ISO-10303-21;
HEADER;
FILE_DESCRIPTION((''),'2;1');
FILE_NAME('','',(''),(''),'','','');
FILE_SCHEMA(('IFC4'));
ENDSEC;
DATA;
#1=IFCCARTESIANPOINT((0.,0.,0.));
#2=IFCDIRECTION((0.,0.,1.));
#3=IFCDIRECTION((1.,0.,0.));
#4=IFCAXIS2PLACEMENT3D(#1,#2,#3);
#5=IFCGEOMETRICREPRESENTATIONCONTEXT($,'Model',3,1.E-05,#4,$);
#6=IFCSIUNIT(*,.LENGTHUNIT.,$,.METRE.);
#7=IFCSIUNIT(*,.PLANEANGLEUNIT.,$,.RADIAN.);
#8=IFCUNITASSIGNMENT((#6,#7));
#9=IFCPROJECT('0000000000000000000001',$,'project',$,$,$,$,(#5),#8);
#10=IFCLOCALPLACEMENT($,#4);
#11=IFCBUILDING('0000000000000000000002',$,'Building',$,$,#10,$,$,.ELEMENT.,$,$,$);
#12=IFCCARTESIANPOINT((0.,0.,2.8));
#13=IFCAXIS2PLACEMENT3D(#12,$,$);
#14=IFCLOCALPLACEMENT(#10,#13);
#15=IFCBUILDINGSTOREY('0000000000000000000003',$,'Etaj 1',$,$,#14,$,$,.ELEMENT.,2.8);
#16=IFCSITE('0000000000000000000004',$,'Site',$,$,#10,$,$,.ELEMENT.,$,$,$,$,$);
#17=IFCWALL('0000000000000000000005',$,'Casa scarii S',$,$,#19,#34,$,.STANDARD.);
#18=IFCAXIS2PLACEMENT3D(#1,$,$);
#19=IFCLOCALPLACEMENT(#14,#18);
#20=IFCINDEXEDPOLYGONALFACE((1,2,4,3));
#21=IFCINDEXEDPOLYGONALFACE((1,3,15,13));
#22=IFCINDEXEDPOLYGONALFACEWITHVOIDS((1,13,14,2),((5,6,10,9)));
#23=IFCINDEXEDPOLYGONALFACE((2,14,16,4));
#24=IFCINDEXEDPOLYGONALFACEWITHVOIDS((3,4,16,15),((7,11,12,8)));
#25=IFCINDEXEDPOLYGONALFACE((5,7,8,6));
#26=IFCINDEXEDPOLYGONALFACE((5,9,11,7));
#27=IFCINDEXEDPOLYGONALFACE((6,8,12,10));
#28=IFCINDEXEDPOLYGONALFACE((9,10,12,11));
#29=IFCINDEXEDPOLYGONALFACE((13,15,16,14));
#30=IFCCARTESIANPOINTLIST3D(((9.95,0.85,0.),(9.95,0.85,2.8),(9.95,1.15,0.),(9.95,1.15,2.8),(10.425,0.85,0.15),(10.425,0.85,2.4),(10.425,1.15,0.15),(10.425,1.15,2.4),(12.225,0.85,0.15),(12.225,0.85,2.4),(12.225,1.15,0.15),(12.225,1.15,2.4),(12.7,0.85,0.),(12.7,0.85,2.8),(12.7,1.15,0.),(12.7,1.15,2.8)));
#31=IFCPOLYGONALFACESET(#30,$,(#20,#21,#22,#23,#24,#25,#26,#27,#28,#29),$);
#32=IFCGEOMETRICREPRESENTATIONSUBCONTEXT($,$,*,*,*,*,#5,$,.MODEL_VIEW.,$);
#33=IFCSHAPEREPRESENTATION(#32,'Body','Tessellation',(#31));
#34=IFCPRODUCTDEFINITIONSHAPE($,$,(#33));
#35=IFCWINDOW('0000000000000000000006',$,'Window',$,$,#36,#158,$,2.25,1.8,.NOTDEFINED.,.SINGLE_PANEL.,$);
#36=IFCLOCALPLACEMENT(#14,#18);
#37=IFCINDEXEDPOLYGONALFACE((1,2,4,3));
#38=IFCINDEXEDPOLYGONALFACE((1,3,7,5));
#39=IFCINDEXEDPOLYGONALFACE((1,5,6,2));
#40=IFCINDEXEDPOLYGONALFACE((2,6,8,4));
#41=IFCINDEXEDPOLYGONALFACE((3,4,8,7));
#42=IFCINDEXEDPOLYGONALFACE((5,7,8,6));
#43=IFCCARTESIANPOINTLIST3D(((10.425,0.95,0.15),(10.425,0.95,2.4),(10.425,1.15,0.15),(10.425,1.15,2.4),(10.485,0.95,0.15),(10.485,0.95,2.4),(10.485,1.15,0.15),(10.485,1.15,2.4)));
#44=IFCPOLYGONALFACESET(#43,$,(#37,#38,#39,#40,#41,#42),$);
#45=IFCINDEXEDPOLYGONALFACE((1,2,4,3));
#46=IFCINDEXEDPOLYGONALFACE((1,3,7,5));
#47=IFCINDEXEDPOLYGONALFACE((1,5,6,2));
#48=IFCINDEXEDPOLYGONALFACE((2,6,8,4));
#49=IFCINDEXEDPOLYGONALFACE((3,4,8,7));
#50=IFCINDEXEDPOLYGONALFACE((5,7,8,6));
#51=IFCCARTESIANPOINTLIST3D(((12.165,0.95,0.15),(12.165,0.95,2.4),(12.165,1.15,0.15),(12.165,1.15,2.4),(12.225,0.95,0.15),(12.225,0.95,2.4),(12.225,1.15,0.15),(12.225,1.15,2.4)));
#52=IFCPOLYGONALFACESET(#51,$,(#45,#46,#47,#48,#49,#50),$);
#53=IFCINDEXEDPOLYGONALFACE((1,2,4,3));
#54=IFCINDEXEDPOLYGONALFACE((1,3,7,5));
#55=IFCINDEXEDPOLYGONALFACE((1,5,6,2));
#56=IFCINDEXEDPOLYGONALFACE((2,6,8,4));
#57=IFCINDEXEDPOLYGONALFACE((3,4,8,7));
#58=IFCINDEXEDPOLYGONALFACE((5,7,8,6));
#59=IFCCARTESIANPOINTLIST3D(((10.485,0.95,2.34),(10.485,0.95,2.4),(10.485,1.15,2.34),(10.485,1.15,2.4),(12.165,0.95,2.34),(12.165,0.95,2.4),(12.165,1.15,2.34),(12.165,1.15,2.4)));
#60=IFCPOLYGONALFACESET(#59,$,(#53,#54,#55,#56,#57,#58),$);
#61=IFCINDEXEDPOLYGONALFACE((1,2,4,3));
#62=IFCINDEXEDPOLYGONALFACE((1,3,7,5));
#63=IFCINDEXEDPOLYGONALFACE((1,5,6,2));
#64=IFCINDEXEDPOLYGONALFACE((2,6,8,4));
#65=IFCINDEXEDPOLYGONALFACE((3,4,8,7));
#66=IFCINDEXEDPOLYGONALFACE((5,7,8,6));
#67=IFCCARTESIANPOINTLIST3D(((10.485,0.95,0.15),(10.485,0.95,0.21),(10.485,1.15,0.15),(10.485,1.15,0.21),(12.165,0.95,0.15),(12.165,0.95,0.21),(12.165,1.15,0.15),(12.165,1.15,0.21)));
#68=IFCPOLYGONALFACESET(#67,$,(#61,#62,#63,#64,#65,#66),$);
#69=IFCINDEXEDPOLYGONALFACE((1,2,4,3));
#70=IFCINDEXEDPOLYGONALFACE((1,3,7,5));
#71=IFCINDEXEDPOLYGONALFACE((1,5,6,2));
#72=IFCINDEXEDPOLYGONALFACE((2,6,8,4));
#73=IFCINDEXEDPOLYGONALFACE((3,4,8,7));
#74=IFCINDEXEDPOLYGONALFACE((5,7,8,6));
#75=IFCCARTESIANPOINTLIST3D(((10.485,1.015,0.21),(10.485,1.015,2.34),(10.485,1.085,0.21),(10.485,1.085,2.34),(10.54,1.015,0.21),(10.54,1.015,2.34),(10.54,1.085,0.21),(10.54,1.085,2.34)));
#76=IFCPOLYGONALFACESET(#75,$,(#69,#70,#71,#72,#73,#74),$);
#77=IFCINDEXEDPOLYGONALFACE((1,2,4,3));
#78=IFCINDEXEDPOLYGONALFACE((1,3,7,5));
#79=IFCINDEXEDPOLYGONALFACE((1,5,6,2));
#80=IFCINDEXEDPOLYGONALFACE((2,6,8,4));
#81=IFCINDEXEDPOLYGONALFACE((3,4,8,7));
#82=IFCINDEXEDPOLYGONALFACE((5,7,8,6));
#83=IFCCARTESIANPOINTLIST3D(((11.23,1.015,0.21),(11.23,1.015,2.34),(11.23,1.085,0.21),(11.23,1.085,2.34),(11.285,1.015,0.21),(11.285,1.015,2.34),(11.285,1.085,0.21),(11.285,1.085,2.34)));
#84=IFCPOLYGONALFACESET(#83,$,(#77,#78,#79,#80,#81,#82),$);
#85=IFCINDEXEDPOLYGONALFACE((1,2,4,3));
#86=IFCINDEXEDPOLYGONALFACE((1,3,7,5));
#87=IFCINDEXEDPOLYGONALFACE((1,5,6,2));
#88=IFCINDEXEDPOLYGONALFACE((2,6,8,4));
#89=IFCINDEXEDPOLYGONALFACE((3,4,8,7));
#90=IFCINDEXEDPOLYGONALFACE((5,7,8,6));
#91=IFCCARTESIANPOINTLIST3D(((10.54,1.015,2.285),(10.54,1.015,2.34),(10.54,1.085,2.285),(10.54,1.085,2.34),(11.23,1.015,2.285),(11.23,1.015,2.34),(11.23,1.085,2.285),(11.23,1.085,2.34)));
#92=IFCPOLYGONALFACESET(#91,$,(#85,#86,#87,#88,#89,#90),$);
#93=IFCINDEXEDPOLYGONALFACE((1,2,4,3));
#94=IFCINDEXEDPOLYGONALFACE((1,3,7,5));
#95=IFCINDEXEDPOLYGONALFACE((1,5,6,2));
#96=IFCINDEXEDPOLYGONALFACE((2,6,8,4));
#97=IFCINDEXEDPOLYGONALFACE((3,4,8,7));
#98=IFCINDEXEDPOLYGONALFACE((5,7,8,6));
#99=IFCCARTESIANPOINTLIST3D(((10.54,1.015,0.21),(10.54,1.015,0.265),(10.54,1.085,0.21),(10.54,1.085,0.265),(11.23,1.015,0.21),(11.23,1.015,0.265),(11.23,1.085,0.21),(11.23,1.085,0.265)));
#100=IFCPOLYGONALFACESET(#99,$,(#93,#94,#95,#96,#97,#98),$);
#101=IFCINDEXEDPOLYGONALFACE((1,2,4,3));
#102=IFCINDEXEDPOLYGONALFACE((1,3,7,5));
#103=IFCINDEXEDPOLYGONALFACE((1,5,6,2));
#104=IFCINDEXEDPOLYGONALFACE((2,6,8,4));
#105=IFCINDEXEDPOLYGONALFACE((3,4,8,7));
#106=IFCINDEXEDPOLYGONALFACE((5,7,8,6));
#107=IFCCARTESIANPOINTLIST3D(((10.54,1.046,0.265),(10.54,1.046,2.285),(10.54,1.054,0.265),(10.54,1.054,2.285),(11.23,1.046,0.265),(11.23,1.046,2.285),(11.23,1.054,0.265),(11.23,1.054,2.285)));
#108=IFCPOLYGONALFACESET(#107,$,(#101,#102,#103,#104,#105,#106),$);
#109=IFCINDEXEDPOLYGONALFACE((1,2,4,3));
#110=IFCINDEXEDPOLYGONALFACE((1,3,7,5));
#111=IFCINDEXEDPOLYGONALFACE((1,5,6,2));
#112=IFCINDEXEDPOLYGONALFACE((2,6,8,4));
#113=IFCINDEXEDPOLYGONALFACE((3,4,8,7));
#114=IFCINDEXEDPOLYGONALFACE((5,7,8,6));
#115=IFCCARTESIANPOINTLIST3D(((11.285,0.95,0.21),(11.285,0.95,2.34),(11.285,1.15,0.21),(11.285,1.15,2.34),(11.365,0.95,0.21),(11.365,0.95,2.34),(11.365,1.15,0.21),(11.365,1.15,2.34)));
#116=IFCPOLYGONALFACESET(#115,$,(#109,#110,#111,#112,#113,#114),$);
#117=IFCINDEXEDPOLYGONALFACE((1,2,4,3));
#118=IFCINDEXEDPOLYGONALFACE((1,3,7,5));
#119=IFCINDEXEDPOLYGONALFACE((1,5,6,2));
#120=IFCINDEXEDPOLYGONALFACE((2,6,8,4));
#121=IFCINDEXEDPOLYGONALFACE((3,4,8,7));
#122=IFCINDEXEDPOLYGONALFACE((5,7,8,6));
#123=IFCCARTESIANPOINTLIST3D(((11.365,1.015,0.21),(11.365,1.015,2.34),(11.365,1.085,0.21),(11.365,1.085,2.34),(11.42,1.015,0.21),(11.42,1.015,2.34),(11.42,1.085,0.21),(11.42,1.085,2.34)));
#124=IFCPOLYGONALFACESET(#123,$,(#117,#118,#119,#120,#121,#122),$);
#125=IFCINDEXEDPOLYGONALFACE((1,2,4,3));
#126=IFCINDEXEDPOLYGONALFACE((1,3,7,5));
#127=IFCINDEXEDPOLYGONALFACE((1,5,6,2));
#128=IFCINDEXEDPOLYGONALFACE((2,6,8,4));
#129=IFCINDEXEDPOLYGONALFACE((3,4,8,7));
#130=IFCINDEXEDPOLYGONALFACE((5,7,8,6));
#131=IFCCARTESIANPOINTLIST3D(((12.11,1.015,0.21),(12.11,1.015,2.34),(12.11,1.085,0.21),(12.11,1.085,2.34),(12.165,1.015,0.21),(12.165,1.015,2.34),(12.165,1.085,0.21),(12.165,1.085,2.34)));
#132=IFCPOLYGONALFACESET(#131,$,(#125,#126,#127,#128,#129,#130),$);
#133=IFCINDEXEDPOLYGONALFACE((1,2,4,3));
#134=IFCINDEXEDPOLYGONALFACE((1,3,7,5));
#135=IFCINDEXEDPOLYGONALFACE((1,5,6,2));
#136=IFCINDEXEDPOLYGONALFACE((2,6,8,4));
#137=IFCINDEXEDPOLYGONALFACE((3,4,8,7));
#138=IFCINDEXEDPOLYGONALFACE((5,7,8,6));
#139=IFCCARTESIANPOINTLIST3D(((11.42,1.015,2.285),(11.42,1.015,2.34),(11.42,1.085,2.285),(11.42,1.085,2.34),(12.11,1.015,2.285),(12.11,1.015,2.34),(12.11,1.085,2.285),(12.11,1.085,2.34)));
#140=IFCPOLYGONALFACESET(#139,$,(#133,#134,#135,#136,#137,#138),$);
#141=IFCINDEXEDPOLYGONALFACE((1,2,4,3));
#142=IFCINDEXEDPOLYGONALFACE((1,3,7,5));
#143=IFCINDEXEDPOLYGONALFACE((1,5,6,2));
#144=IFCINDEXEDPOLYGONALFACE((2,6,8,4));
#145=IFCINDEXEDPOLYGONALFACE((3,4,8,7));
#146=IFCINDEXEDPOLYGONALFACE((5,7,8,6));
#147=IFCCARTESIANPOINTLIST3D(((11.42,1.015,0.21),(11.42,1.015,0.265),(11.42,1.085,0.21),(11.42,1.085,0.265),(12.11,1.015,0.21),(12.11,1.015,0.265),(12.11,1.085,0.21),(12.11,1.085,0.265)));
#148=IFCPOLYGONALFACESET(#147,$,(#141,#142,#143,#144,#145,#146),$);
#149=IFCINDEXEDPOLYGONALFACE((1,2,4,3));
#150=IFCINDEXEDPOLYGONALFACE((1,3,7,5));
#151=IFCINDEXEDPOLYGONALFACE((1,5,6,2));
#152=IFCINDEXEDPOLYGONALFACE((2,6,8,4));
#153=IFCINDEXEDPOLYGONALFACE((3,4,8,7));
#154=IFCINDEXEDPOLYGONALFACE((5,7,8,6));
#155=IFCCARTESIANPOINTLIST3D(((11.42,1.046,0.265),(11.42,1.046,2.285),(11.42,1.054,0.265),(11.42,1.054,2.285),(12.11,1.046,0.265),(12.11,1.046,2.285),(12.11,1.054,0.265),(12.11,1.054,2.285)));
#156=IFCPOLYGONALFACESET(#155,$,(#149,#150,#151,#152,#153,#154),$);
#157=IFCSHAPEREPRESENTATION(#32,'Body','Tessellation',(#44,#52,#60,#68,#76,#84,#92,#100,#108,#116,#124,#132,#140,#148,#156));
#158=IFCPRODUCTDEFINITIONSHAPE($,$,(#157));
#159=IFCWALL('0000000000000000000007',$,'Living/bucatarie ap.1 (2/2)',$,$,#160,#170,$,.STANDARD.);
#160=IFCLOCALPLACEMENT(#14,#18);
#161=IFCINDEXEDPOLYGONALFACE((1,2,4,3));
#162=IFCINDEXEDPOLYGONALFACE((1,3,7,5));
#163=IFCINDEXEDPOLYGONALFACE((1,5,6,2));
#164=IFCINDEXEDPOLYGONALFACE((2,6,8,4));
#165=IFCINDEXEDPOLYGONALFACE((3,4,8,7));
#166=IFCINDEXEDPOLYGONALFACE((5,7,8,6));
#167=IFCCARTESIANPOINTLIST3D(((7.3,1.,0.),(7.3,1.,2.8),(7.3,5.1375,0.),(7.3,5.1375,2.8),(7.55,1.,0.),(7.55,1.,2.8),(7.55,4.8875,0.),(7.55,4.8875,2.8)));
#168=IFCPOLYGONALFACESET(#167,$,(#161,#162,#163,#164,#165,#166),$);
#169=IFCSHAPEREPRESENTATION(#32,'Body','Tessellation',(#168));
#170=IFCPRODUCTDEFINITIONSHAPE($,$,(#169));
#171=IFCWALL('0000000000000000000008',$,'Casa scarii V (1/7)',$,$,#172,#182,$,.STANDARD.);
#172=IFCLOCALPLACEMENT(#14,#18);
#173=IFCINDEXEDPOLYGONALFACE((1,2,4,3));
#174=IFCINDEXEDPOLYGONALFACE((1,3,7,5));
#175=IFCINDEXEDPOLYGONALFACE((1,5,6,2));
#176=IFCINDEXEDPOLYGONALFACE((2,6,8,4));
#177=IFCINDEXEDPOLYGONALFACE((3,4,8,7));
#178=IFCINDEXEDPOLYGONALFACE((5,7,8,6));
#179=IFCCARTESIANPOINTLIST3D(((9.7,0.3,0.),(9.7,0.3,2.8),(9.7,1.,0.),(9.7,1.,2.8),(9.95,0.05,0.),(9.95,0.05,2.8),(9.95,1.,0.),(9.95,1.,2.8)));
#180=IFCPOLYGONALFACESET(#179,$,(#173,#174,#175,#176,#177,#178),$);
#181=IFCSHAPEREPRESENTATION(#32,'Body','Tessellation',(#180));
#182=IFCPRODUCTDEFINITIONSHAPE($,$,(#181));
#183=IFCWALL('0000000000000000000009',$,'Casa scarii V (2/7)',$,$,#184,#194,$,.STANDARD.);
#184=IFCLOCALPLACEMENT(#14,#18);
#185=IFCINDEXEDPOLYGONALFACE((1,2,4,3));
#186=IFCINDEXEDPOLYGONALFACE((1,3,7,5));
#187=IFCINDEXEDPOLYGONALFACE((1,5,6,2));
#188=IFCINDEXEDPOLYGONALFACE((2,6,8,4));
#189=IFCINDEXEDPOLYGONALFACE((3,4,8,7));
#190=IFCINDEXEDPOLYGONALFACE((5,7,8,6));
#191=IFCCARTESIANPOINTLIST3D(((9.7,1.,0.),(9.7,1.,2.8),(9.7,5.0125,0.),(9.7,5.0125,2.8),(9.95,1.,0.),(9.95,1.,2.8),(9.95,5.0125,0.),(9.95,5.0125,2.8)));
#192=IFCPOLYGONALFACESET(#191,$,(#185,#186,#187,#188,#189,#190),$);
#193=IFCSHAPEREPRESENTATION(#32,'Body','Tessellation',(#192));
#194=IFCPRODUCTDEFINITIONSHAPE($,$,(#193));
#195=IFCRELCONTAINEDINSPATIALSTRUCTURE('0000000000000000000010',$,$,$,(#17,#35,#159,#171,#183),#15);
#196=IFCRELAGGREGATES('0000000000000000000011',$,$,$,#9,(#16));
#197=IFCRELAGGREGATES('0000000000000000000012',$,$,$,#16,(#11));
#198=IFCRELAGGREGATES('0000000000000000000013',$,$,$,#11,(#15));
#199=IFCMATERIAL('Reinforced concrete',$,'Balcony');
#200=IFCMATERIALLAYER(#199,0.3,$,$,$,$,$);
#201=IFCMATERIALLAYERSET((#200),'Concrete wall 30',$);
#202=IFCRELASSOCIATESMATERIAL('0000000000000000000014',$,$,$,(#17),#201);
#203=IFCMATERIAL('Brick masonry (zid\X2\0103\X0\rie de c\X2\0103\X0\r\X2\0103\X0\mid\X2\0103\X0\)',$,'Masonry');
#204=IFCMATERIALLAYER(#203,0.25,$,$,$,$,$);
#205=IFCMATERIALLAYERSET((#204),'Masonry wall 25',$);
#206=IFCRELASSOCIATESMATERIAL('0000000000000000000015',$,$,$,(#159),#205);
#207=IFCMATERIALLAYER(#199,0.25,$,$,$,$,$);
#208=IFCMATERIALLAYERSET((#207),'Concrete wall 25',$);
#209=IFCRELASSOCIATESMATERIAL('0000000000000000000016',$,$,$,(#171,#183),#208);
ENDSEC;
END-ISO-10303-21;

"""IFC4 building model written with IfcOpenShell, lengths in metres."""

from ifc_helpers import new_model, si_unit, frame, frame_2d, origin, origin_with_axes, origin_2d, place, context, subcontext, project, spatial, rectangle, extrude, clip, halfspace, material, layer, layer_set, layer_usage, element, fill, save


model = new_model("IFC4")

# Units and contexts
model_context = context("Model", 3, precision=1e-05, world=origin_with_axes())
sub_context = subcontext(model_context, None, None, "MODEL_VIEW")
ifc_project = project(units=[si_unit("LENGTHUNIT", "METRE"), si_unit("PLANEANGLEUNIT", "RADIAN")], contexts=[model_context])

# Site, building, storey
placement = place(None, origin_with_axes())
site = spatial("IfcSite", under=ifc_project, at=placement, Name="Site", CompositionType="ELEMENT")
building = spatial("IfcBuilding", under=site, at=placement, Name="Building", CompositionType="ELEMENT")
storey_placement = place(placement, frame((0.0, 0.0, 2.8)))
storey = spatial("IfcBuildingStorey", under=building, at=storey_placement, Name="Etaj 1", CompositionType="ELEMENT", Elevation=2.8)

# Shared definitions
ifc_material_1 = material(Name="Reinforced concrete", Category="Balcony")

# Wall, opening, window
ifc_material_2 = material(Name="Brick masonry (zidărie de cărămidă)", Category="Masonry")
ifc_layer_1 = layer(ifc_material_1, 0.3)
ifc_layer_set_1 = layer_set([ifc_layer_1], Name="Concrete wall 30")
ifc_layer_usage_1 = layer_usage(ifc_layer_set_1, "AXIS2", "POSITIVE", -0.15)
wall_1_placement = place(storey_placement, frame((9.95, 1.0, 0.0), x_axis=(1.0, 0.0, 0.0)))
wall_1 = element("IfcWall", 1, at=wall_1_placement, inside=storey, material=ifc_layer_usage_1, Name="Casa scarii S", PredefinedType="STANDARD", context=sub_context, shape_type="SweptSolid", body=[
    extrude(rectangle(XDim=2.75, YDim=0.3, at=frame_2d((1.375, 0.0))), origin(), (0.0, 0.0, 1.0), 2.8),
])
opening_1_placement = place(wall_1_placement, frame((1.375, 0.2, 0.15), z_axis=(0.0, -1.0, 0.0), x_axis=(1.0, 0.0, 0.0)))
opening_1 = element("IfcOpeningElement", 2, at=opening_1_placement, cuts=wall_1, PredefinedType="OPENING", context=sub_context, shape_type="SweptSolid", body=[
    extrude(rectangle(XDim=1.8, YDim=2.25, at=frame_2d((0.0, 1.125))), origin(), (0.0, 0.0, 1.0), 0.4),
])
window_1_placement = place(wall_1_placement, frame((1.375, 0.15, 0.15), z_axis=(0.0, -1.0, 0.0), x_axis=(1.0, 0.0, 0.0)))
window_1 = element("IfcWindow", 3, at=window_1_placement, inside=storey, Name="Window", OverallHeight=2.25, OverallWidth=1.8, PartitioningType="SINGLE_PANEL", PredefinedType="NOTDEFINED", context=sub_context, shape_type="SweptSolid", body=[
    extrude(rectangle(XDim=0.06, YDim=2.25, at=origin_2d()), frame((-0.87, 1.125, 0.0)), (0.0, 0.0, 1.0), 0.2),
    extrude(rectangle(XDim=0.06, YDim=2.25, at=origin_2d()), frame((0.87, 1.125, 0.0)), (0.0, 0.0, 1.0), 0.2),
    extrude(rectangle(XDim=1.68, YDim=0.06, at=origin_2d()), frame((0.0, 2.22, 0.0)), (0.0, 0.0, 1.0), 0.2),
    extrude(rectangle(XDim=1.68, YDim=0.06, at=origin_2d()), frame((0.0, 0.03, 0.0)), (0.0, 0.0, 1.0), 0.2),
    extrude(rectangle(XDim=0.055, YDim=2.13, at=origin_2d()), frame((-0.8125, 1.125, 0.065)), (0.0, 0.0, 1.0), 0.07),
    extrude(rectangle(XDim=0.055, YDim=2.13, at=origin_2d()), frame((-0.0675, 1.125, 0.065)), (0.0, 0.0, 1.0), 0.07),
    extrude(rectangle(XDim=0.69, YDim=0.055, at=origin_2d()), frame((-0.44, 2.1625, 0.065)), (0.0, 0.0, 1.0), 0.07),
    extrude(rectangle(XDim=0.69, YDim=0.055, at=origin_2d()), frame((-0.44, 0.0875, 0.065)), (0.0, 0.0, 1.0), 0.07),
    extrude(rectangle(XDim=0.69, YDim=2.02, at=origin_2d()), frame((-0.44, 1.125, 0.096)), (0.0, 0.0, 1.0), 0.008),
    extrude(rectangle(XDim=0.08, YDim=2.13, at=origin_2d()), frame((0.0, 1.125, 0.0)), (0.0, 0.0, 1.0), 0.2),
    extrude(rectangle(XDim=0.055, YDim=2.13, at=origin_2d()), frame((0.0675, 1.125, 0.065)), (0.0, 0.0, 1.0), 0.07),
    extrude(rectangle(XDim=0.055, YDim=2.13, at=origin_2d()), frame((0.8125, 1.125, 0.065)), (0.0, 0.0, 1.0), 0.07),
    extrude(rectangle(XDim=0.69, YDim=0.055, at=origin_2d()), frame((0.44, 2.1625, 0.065)), (0.0, 0.0, 1.0), 0.07),
    extrude(rectangle(XDim=0.69, YDim=0.055, at=origin_2d()), frame((0.44, 0.0875, 0.065)), (0.0, 0.0, 1.0), 0.07),
    extrude(rectangle(XDim=0.69, YDim=2.02, at=origin_2d()), frame((0.44, 1.125, 0.096)), (0.0, 0.0, 1.0), 0.008),
])
fill(opening_1, window_1)

# Walls
ifc_layer_2 = layer(ifc_material_2, 0.25)
ifc_layer_set_2 = layer_set([ifc_layer_2], Name="Masonry wall 25")
ifc_layer_usage_2 = layer_usage(ifc_layer_set_2, "AXIS2", "POSITIVE", -0.125)
wall_2_placement = place(storey_placement, frame((7.425, 1.0, 0.0), x_axis=(0.0, 1.0, 0.0)))
element("IfcWall", 4, at=wall_2_placement, inside=storey, material=ifc_layer_usage_2, Name="Living/bucatarie ap.1 (2/2)", PredefinedType="STANDARD", context=sub_context, shape_type="CSG", body=[
    clip(extrude(rectangle(XDim=4.1375, YDim=0.25, at=frame_2d((2.0688, 0.0))), origin(), (0.0, 0.0, 1.0), 2.8), halfspace(frame((4.0125, 0.0, 0.0), z_axis=(0.707107, -0.707107, 0.0)), False)),
])
ifc_layer_3 = layer(ifc_material_1, 0.25)
ifc_layer_set_3 = layer_set([ifc_layer_3], Name="Concrete wall 25")
ifc_layer_usage_3 = layer_usage(ifc_layer_set_3, "AXIS2", "POSITIVE", -0.125)
wall_3_placement = place(storey_placement, frame((9.825, 0.05, 0.0), x_axis=(0.0, 1.0, 0.0)))
element("IfcWall", 5, at=wall_3_placement, inside=storey, material=ifc_layer_usage_3, Name="Casa scarii V (1/7)", PredefinedType="STANDARD", context=sub_context, shape_type="CSG", body=[
    clip(extrude(rectangle(XDim=0.95, YDim=0.25, at=frame_2d((0.475, 0.0))), origin(), (0.0, 0.0, 1.0), 2.8), halfspace(frame((0.125, 0.0, 0.0), z_axis=(-0.707107, 0.707107, 0.0)), False)),
])
wall_4_placement = place(storey_placement, frame((9.825, 1.0, 0.0), x_axis=(0.0, 1.0, 0.0)))
element("IfcWall", 6, at=wall_4_placement, inside=storey, material=ifc_layer_usage_3, Name="Casa scarii V (2/7)", PredefinedType="STANDARD", context=sub_context, shape_type="SweptSolid", body=[
    extrude(rectangle(XDim=4.0125, YDim=0.25, at=frame_2d((2.0063, 0.0))), origin(), (0.0, 0.0, 1.0), 2.8),
])

save(model, "model.ifc")
